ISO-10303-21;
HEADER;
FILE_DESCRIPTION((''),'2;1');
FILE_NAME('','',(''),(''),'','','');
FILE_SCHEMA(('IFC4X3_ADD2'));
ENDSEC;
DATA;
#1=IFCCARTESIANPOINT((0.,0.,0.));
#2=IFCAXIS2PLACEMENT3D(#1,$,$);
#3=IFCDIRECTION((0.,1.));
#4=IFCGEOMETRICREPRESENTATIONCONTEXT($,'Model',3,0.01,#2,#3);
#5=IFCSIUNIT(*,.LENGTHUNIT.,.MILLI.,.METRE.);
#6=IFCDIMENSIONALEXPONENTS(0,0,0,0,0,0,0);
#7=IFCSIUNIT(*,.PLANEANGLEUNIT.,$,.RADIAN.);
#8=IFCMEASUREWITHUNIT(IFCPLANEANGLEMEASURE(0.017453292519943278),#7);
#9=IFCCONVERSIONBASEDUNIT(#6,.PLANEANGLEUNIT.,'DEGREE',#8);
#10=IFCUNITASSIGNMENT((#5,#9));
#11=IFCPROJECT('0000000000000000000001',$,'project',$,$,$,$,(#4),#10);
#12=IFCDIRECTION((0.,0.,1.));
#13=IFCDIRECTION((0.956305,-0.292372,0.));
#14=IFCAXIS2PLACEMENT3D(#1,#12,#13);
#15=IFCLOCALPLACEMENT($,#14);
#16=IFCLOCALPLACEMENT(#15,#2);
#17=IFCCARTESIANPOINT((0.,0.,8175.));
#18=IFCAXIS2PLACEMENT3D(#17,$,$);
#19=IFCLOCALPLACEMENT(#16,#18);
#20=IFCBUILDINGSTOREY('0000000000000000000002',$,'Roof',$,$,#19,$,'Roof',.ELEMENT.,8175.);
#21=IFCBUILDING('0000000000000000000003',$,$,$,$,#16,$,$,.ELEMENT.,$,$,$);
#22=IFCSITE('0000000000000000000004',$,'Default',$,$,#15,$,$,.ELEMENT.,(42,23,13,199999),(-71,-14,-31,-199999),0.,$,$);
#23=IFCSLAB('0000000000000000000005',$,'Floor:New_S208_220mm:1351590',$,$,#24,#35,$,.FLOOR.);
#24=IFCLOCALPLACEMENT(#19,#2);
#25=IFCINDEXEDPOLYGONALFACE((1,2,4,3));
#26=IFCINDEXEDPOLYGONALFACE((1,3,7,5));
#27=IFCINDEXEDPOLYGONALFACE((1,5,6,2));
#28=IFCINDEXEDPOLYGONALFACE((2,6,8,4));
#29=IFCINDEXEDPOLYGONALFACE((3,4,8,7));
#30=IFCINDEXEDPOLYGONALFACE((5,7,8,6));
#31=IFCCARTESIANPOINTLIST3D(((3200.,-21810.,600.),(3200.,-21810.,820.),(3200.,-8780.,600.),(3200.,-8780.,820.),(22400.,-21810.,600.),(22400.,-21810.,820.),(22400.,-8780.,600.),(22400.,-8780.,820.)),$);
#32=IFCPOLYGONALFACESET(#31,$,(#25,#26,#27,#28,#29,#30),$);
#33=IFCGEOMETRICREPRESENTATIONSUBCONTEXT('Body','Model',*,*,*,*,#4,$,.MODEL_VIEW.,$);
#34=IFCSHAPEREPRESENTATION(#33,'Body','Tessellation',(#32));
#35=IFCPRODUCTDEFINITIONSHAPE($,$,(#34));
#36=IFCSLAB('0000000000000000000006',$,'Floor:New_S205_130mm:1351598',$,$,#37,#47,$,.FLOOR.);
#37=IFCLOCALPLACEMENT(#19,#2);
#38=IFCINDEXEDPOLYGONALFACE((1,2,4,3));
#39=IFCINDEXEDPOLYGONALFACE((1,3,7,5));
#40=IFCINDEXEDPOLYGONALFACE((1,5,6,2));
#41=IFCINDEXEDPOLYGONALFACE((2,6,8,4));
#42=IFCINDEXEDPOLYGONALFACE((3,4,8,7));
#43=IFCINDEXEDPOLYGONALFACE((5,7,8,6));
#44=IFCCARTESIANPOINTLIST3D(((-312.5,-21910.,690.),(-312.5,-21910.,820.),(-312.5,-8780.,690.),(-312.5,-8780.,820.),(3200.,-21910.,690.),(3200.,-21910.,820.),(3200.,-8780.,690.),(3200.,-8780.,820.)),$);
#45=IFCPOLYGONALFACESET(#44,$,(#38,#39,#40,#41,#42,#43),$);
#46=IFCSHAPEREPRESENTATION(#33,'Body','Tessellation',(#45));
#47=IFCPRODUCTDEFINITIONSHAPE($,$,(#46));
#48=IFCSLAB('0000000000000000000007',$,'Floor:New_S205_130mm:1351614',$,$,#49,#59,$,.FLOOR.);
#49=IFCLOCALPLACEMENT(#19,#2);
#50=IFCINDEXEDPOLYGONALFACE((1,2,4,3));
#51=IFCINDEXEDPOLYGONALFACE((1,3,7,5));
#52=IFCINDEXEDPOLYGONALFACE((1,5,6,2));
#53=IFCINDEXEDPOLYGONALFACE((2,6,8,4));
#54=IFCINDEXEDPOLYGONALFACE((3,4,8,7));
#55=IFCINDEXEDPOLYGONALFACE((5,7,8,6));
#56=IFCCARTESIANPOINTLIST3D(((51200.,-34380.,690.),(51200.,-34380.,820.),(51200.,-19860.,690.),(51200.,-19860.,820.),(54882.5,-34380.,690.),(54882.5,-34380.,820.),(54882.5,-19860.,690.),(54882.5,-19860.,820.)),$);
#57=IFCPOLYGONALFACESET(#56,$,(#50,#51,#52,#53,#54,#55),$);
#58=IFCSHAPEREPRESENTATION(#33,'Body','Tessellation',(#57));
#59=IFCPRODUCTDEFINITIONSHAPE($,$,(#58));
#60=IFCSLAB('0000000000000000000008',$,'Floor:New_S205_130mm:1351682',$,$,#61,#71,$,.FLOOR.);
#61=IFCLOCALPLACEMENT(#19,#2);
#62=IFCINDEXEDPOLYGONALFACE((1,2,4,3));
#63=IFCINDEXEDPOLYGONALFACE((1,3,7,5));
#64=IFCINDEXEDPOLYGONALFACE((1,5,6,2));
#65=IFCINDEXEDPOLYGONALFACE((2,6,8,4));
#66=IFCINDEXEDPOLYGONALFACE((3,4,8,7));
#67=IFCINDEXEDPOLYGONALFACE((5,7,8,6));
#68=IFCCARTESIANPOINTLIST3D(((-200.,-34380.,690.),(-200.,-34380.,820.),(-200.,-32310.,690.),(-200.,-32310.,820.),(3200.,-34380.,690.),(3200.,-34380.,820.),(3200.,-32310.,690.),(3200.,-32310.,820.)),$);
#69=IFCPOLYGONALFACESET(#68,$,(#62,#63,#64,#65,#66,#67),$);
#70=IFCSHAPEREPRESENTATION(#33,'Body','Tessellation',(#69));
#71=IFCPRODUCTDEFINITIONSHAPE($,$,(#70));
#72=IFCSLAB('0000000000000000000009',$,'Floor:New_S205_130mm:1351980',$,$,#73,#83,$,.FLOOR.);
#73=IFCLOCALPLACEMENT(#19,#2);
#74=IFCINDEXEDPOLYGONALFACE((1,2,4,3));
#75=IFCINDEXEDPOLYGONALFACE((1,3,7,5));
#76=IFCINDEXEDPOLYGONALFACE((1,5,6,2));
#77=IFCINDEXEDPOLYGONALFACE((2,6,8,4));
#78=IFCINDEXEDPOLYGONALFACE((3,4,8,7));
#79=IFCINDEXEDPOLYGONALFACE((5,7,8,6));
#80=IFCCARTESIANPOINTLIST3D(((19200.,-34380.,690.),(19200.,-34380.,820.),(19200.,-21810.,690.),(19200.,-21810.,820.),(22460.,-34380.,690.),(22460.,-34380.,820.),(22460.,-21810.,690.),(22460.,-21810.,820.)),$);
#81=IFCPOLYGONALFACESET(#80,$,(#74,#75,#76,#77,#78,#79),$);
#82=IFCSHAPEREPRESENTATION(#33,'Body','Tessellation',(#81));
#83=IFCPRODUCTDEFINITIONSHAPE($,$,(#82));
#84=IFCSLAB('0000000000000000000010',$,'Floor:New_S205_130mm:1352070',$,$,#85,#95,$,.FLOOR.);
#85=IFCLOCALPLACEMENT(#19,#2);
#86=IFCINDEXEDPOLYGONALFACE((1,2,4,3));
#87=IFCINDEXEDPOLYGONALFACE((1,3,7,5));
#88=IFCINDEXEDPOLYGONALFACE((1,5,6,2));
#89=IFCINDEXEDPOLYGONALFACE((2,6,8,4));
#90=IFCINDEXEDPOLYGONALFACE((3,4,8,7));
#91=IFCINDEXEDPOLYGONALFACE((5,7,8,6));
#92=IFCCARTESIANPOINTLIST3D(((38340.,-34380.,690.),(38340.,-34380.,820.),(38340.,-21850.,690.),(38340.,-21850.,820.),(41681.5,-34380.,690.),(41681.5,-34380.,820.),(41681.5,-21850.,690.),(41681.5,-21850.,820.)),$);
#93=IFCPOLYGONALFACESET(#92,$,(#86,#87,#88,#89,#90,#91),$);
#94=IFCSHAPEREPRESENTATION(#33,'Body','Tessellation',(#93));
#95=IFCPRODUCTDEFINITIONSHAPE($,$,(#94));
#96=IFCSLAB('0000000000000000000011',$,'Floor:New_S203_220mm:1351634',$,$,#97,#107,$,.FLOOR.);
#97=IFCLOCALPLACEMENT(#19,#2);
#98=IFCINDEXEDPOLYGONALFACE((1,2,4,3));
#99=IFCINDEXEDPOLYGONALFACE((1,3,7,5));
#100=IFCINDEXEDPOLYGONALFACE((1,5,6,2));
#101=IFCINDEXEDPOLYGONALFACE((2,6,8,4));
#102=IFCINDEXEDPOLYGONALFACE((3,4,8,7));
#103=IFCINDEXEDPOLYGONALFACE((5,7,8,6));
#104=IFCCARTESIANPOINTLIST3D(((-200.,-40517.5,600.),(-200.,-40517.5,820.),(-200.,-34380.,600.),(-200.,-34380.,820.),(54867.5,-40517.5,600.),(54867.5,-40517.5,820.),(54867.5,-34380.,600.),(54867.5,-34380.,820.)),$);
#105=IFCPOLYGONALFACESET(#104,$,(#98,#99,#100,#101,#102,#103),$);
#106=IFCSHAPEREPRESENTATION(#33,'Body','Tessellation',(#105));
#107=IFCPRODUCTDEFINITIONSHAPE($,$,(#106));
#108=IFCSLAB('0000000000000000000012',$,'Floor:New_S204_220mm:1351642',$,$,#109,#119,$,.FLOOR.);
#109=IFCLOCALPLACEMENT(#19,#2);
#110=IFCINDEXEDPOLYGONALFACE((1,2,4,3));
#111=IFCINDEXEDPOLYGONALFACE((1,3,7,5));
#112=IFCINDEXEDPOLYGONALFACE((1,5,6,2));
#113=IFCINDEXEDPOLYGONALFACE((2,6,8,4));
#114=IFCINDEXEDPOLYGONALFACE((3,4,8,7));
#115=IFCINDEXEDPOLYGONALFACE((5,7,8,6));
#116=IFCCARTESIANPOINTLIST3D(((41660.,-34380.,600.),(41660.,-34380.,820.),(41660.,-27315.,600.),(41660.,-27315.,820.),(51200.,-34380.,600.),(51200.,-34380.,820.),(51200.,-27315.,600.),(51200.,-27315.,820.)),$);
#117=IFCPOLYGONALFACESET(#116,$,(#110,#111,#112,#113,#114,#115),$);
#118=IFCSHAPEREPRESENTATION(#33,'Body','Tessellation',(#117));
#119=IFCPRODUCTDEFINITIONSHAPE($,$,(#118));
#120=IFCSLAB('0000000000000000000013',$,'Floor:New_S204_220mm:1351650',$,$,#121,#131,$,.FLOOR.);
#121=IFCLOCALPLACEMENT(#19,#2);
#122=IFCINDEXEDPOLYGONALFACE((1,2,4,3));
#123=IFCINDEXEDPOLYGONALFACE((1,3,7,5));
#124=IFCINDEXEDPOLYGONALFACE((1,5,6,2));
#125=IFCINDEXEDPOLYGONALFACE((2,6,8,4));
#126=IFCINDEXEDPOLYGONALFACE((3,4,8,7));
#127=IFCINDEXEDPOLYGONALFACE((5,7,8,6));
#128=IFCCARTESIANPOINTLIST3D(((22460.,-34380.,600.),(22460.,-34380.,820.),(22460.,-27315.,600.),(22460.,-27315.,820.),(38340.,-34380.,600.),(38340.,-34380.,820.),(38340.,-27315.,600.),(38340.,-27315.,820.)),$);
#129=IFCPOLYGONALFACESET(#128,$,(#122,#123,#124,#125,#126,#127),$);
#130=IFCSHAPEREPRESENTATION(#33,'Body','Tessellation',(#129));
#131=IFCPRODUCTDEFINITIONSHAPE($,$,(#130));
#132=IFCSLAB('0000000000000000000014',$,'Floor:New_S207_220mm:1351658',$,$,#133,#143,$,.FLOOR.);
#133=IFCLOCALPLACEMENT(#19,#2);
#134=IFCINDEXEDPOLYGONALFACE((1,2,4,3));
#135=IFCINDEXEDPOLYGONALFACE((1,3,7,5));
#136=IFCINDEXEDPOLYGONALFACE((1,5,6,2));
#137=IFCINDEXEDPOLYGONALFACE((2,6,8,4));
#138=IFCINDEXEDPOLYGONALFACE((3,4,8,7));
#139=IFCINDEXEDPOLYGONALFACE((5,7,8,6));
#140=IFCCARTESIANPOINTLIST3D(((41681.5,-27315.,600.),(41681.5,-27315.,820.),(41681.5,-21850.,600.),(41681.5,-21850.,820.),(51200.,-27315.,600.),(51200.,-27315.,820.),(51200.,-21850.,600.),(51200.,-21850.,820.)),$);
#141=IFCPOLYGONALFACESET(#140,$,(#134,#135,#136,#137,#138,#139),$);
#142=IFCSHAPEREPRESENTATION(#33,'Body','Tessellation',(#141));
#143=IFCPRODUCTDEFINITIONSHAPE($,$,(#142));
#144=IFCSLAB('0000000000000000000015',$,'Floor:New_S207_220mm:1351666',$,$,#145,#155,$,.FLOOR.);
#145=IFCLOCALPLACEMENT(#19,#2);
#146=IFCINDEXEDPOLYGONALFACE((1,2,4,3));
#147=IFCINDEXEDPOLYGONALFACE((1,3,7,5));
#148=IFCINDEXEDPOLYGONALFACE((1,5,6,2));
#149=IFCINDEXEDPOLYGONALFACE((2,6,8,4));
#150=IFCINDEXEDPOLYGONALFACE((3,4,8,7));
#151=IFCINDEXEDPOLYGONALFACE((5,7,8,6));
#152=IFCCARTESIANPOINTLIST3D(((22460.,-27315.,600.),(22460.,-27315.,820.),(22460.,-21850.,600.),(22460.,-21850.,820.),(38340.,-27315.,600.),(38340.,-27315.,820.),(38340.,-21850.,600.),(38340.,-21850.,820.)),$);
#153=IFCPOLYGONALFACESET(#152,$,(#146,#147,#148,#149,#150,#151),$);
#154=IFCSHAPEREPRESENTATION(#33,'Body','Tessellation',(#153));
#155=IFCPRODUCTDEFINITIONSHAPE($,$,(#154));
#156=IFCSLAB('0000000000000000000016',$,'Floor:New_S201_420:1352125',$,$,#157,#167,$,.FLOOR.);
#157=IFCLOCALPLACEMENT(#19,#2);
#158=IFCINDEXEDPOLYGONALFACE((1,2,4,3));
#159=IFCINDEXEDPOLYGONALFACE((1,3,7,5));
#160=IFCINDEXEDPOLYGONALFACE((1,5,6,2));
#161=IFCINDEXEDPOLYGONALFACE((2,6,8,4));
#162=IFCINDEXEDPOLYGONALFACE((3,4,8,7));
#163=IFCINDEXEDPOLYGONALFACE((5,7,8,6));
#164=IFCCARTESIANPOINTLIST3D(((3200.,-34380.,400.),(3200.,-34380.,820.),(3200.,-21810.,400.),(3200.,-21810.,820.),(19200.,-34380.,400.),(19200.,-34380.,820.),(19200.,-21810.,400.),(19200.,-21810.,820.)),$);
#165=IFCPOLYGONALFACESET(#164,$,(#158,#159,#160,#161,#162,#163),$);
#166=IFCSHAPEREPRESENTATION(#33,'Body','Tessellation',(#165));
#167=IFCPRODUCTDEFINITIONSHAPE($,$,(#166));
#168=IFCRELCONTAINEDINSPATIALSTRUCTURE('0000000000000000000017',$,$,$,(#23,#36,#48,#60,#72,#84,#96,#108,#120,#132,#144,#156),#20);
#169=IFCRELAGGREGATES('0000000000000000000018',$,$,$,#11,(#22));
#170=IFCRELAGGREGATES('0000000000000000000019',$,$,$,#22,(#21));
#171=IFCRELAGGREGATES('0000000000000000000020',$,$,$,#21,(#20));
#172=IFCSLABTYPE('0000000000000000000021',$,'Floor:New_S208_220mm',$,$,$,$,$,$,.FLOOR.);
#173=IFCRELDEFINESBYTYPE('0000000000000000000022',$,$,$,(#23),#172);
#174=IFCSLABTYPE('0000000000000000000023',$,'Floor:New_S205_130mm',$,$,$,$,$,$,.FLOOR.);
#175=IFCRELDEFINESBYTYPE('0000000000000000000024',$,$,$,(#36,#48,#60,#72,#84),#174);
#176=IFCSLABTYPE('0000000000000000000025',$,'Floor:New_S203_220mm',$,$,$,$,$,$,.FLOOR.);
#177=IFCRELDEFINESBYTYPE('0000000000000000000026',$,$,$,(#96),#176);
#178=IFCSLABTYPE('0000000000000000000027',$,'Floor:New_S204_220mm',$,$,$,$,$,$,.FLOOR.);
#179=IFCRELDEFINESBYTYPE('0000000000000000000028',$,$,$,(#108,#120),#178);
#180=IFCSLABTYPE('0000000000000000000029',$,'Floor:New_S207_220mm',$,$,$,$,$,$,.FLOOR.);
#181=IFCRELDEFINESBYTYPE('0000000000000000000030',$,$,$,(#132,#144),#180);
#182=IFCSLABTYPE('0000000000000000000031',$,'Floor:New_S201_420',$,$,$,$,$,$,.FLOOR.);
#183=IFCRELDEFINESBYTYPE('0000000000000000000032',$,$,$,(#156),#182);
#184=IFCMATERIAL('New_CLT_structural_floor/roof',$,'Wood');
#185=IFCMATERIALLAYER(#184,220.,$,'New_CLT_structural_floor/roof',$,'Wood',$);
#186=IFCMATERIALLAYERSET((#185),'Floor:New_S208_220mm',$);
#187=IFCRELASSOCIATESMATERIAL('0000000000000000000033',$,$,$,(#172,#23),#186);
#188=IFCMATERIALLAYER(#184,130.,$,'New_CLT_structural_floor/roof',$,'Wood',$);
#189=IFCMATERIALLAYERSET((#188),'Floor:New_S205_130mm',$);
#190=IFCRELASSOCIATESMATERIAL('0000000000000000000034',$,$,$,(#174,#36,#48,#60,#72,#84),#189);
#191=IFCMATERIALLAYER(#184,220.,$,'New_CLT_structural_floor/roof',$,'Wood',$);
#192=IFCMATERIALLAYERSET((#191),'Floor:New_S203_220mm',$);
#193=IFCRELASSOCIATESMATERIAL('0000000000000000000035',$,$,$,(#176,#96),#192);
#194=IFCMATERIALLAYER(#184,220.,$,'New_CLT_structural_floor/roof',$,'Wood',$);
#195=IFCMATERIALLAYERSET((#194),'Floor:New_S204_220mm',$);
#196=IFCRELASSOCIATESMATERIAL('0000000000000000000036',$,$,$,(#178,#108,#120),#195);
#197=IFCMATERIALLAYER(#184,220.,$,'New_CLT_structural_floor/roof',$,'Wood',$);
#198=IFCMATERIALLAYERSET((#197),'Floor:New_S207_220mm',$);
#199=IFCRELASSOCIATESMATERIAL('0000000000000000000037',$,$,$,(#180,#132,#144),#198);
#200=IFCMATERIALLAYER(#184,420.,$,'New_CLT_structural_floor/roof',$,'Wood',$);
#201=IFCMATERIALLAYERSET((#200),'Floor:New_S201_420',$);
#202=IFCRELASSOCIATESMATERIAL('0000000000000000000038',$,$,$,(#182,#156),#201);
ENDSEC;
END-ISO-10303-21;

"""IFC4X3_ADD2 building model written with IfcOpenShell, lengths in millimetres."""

from ifc_helpers import new_model, entity, si_unit, converted_unit, direction, frame, frame_2d, origin, origin_2d_with_axis, place, context, subcontext, project, spatial, rectangle, extrude, material, layer, layer_set, layer_usage, type_object, element, save


model = new_model("IFC4X3_ADD2")

# Units and contexts
model_context = context("Model", 3, precision=0.01, world=origin(), true_north=direction((0.0, 1.0)))
body_context = subcontext(model_context, "Body", "Model", "MODEL_VIEW")
ifc_project = project(units=[si_unit("LENGTHUNIT", "METRE", prefix="MILLI"), converted_unit("PLANEANGLEUNIT", "DEGREE", entity("IfcPlaneAngleMeasure", 0.017453292519943278), si_unit("PLANEANGLEUNIT", "RADIAN"), dimensions=[0, 0, 0, 0, 0, 0, 0])], contexts=[model_context])

# Site, building, storey
site_placement = place(None, frame((0.0, 0.0, 0.0), z_axis=(0.0, 0.0, 1.0), x_axis=(0.956305, -0.292372, 0.0)))
site = spatial("IfcSite", under=ifc_project, at=site_placement, Name="Default", CompositionType="ELEMENT", RefLatitude=(42, 23, 13, 199999), RefLongitude=(-71, -14, -31, -199999), RefElevation=0.0)
building_placement = place(site_placement, origin())
building = spatial("IfcBuilding", under=site, at=building_placement, CompositionType="ELEMENT")
storey_placement = place(building_placement, frame((0.0, 0.0, 8175.0)))
storey = spatial("IfcBuildingStorey", under=building, at=storey_placement, Name="Roof", LongName="Roof", CompositionType="ELEMENT", Elevation=8175.0)

# Slabs
ifc_material_1 = material(Name="New_CLT_structural_floor/roof", Category="Wood")
ifc_layer_1 = layer(ifc_material_1, 220.0, Name="New_CLT_structural_floor/roof", Category="Wood")
ifc_layer_set_1 = layer_set([ifc_layer_1], Name="Floor:New_S208_220mm")
ifc_layer_usage_1 = layer_usage(ifc_layer_set_1, "AXIS3", "POSITIVE", 0.0)
slab_type_1 = type_object("IfcSlabType", Name="Floor:New_S208_220mm", PredefinedType="FLOOR", material=ifc_layer_set_1)
slab_1_placement = place(storey_placement, origin())
element("IfcSlab", 1, at=slab_1_placement, inside=storey, type_object=slab_type_1, material=ifc_layer_usage_1, Name="Floor:New_S208_220mm:1351590", PredefinedType="FLOOR", context=body_context, shape_type="SweptSolid", body=[
    extrude(rectangle(XDim=13030.0, YDim=19200.0, at=frame_2d((0.0, 0.0), x_axis=(1.0, 0.0))), frame((12800.0, -15295.0, 820.0), z_axis=(0.0, 0.0, -1.0), x_axis=(0.0, 1.0, 0.0)), (0.0, 0.0, 1.0), 220.0),
])
ifc_layer_2 = layer(ifc_material_1, 130.0, Name="New_CLT_structural_floor/roof", Category="Wood")
ifc_layer_set_2 = layer_set([ifc_layer_2], Name="Floor:New_S205_130mm")
ifc_layer_usage_2 = layer_usage(ifc_layer_set_2, "AXIS3", "POSITIVE", 0.0)
slab_type_2 = type_object("IfcSlabType", Name="Floor:New_S205_130mm", PredefinedType="FLOOR", material=ifc_layer_set_2)
slab_2_placement = place(storey_placement, origin())
element("IfcSlab", 2, at=slab_2_placement, inside=storey, type_object=slab_type_2, material=ifc_layer_usage_2, Name="Floor:New_S205_130mm:1351598", PredefinedType="FLOOR", context=body_context, shape_type="SweptSolid", body=[
    extrude(rectangle(XDim=13130.0, YDim=3512.5, at=frame_2d((0.0, 0.0), x_axis=(1.0, 0.0))), frame((1443.7, -15345.0, 820.0), z_axis=(0.0, 0.0, -1.0), x_axis=(0.0, 1.0, 0.0)), (0.0, 0.0, 1.0), 130.0),
])
ifc_layer_usage_3 = layer_usage(ifc_layer_set_2, "AXIS3", "POSITIVE", 0.0)
slab_3_placement = place(storey_placement, origin())
element("IfcSlab", 3, at=slab_3_placement, inside=storey, type_object=slab_type_2, material=ifc_layer_usage_3, Name="Floor:New_S205_130mm:1351614", PredefinedType="FLOOR", context=body_context, shape_type="SweptSolid", body=[
    extrude(rectangle(XDim=14520.0, YDim=3682.5, at=frame_2d((0.0, 0.0), x_axis=(1.0, 0.0))), frame((53041.3, -27120.0, 820.0), z_axis=(0.0, 0.0, -1.0), x_axis=(0.0, 1.0, 0.0)), (0.0, 0.0, 1.0), 130.0),
])
ifc_layer_usage_4 = layer_usage(ifc_layer_set_2, "AXIS3", "POSITIVE", 0.0)
slab_4_placement = place(storey_placement, origin())
element("IfcSlab", 4, at=slab_4_placement, inside=storey, type_object=slab_type_2, material=ifc_layer_usage_4, Name="Floor:New_S205_130mm:1351682", PredefinedType="FLOOR", context=body_context, shape_type="SweptSolid", body=[
    extrude(rectangle(XDim=2070.0, YDim=3400.0, at=frame_2d((0.0, 0.0), x_axis=(1.0, 0.0))), frame((1500.0, -33345.0, 820.0), z_axis=(0.0, 0.0, -1.0), x_axis=(0.0, 1.0, 0.0)), (0.0, 0.0, 1.0), 130.0),
])
ifc_layer_usage_5 = layer_usage(ifc_layer_set_2, "AXIS3", "POSITIVE", 0.0)
slab_5_placement = place(storey_placement, origin())
element("IfcSlab", 5, at=slab_5_placement, inside=storey, type_object=slab_type_2, material=ifc_layer_usage_5, Name="Floor:New_S205_130mm:1351980", PredefinedType="FLOOR", context=body_context, shape_type="SweptSolid", body=[
    extrude(rectangle(XDim=12570.0, YDim=3260.0, at=frame_2d((0.0, 0.0), x_axis=(1.0, 0.0))), frame((20830.0, -28095.0, 820.0), z_axis=(0.0, 0.0, -1.0), x_axis=(0.0, 1.0, 0.0)), (0.0, 0.0, 1.0), 130.0),
])
ifc_layer_usage_6 = layer_usage(ifc_layer_set_2, "AXIS3", "POSITIVE", 0.0)
slab_6_placement = place(storey_placement, origin())
element("IfcSlab", 6, at=slab_6_placement, inside=storey, type_object=slab_type_2, material=ifc_layer_usage_6, Name="Floor:New_S205_130mm:1352070", PredefinedType="FLOOR", context=body_context, shape_type="SweptSolid", body=[
    extrude(rectangle(XDim=12530.0, YDim=3341.5, at=frame_2d((0.0, 0.0), x_axis=(1.0, 0.0))), frame((40010.7, -28115.0, 820.0), z_axis=(0.0, 0.0, -1.0), x_axis=(0.0, 1.0, 0.0)), (0.0, 0.0, 1.0), 130.0),
])
ifc_layer_3 = layer(ifc_material_1, 220.0, Name="New_CLT_structural_floor/roof", Category="Wood")
ifc_layer_set_3 = layer_set([ifc_layer_3], Name="Floor:New_S203_220mm")
ifc_layer_usage_7 = layer_usage(ifc_layer_set_3, "AXIS3", "POSITIVE", 0.0)
slab_type_3 = type_object("IfcSlabType", Name="Floor:New_S203_220mm", PredefinedType="FLOOR", material=ifc_layer_set_3)
slab_7_placement = place(storey_placement, origin())
element("IfcSlab", 7, at=slab_7_placement, inside=storey, type_object=slab_type_3, material=ifc_layer_usage_7, Name="Floor:New_S203_220mm:1351634", PredefinedType="FLOOR", context=body_context, shape_type="SweptSolid", body=[
    extrude(rectangle(XDim=6137.5, YDim=55067.5, at=frame_2d((0.0, 0.0), x_axis=(1.0, 0.0))), frame((27333.7, -37448.8, 820.0), z_axis=(0.0, 0.0, -1.0), x_axis=(0.0, 1.0, 0.0)), (0.0, 0.0, 1.0), 220.0),
])
ifc_layer_4 = layer(ifc_material_1, 220.0, Name="New_CLT_structural_floor/roof", Category="Wood")
ifc_layer_set_4 = layer_set([ifc_layer_4], Name="Floor:New_S204_220mm")
ifc_layer_usage_8 = layer_usage(ifc_layer_set_4, "AXIS3", "POSITIVE", 0.0)
slab_type_4 = type_object("IfcSlabType", Name="Floor:New_S204_220mm", PredefinedType="FLOOR", material=ifc_layer_set_4)
slab_8_placement = place(storey_placement, origin())
element("IfcSlab", 8, at=slab_8_placement, inside=storey, type_object=slab_type_4, material=ifc_layer_usage_8, Name="Floor:New_S204_220mm:1351642", PredefinedType="FLOOR", context=body_context, shape_type="SweptSolid", body=[
    extrude(rectangle(XDim=7065.0, YDim=9540.0, at=origin_2d_with_axis()), frame((46430.0, -30847.5, 820.0), z_axis=(0.0, 0.0, -1.0), x_axis=(0.0, 1.0, 0.0)), (0.0, 0.0, 1.0), 220.0),
])
ifc_layer_usage_9 = layer_usage(ifc_layer_set_4, "AXIS3", "POSITIVE", 0.0)
slab_9_placement = place(storey_placement, origin())
element("IfcSlab", 9, at=slab_9_placement, inside=storey, type_object=slab_type_4, material=ifc_layer_usage_9, Name="Floor:New_S204_220mm:1351650", PredefinedType="FLOOR", context=body_context, shape_type="SweptSolid", body=[
    extrude(rectangle(XDim=7065.0, YDim=15880.0, at=frame_2d((0.0, 0.0), x_axis=(1.0, 0.0))), frame((30400.0, -30847.5, 820.0), z_axis=(0.0, 0.0, -1.0), x_axis=(0.0, 1.0, 0.0)), (0.0, 0.0, 1.0), 220.0),
])
ifc_layer_5 = layer(ifc_material_1, 220.0, Name="New_CLT_structural_floor/roof", Category="Wood")
ifc_layer_set_5 = layer_set([ifc_layer_5], Name="Floor:New_S207_220mm")
ifc_layer_usage_10 = layer_usage(ifc_layer_set_5, "AXIS3", "POSITIVE", 0.0)
slab_type_5 = type_object("IfcSlabType", Name="Floor:New_S207_220mm", PredefinedType="FLOOR", material=ifc_layer_set_5)
slab_10_placement = place(storey_placement, origin())
element("IfcSlab", 10, at=slab_10_placement, inside=storey, type_object=slab_type_5, material=ifc_layer_usage_10, Name="Floor:New_S207_220mm:1351658", PredefinedType="FLOOR", context=body_context, shape_type="SweptSolid", body=[
    extrude(rectangle(XDim=5465.0, YDim=9518.5, at=frame_2d((0.0, 0.0), x_axis=(1.0, 0.0))), frame((46440.8, -24582.5, 820.0), z_axis=(0.0, 0.0, -1.0), x_axis=(0.0, 1.0, 0.0)), (0.0, 0.0, 1.0), 220.0),
])
ifc_layer_usage_11 = layer_usage(ifc_layer_set_5, "AXIS3", "POSITIVE", 0.0)
slab_11_placement = place(storey_placement, origin())
element("IfcSlab", 11, at=slab_11_placement, inside=storey, type_object=slab_type_5, material=ifc_layer_usage_11, Name="Floor:New_S207_220mm:1351666", PredefinedType="FLOOR", context=body_context, shape_type="SweptSolid", body=[
    extrude(rectangle(XDim=5465.0, YDim=15880.0, at=frame_2d((0.0, 0.0), x_axis=(1.0, 0.0))), frame((30400.0, -24582.5, 820.0), z_axis=(0.0, 0.0, -1.0), x_axis=(0.0, 1.0, 0.0)), (0.0, 0.0, 1.0), 220.0),
])
ifc_layer_6 = layer(ifc_material_1, 420.0, Name="New_CLT_structural_floor/roof", Category="Wood")
ifc_layer_set_6 = layer_set([ifc_layer_6], Name="Floor:New_S201_420")
ifc_layer_usage_12 = layer_usage(ifc_layer_set_6, "AXIS3", "POSITIVE", 0.0)
slab_type_6 = type_object("IfcSlabType", Name="Floor:New_S201_420", PredefinedType="FLOOR", material=ifc_layer_set_6)
slab_12_placement = place(storey_placement, origin())
element("IfcSlab", 12, at=slab_12_placement, inside=storey, type_object=slab_type_6, material=ifc_layer_usage_12, Name="Floor:New_S201_420:1352125", PredefinedType="FLOOR", context=body_context, shape_type="SweptSolid", body=[
    extrude(rectangle(XDim=12570.0, YDim=16000.0, at=frame_2d((0.0, 0.0), x_axis=(1.0, 0.0))), frame((11200.0, -28095.0, 820.0), z_axis=(0.0, 0.0, -1.0), x_axis=(0.0, 1.0, 0.0)), (0.0, 0.0, 1.0), 420.0),
])

save(model, "model.ifc")
